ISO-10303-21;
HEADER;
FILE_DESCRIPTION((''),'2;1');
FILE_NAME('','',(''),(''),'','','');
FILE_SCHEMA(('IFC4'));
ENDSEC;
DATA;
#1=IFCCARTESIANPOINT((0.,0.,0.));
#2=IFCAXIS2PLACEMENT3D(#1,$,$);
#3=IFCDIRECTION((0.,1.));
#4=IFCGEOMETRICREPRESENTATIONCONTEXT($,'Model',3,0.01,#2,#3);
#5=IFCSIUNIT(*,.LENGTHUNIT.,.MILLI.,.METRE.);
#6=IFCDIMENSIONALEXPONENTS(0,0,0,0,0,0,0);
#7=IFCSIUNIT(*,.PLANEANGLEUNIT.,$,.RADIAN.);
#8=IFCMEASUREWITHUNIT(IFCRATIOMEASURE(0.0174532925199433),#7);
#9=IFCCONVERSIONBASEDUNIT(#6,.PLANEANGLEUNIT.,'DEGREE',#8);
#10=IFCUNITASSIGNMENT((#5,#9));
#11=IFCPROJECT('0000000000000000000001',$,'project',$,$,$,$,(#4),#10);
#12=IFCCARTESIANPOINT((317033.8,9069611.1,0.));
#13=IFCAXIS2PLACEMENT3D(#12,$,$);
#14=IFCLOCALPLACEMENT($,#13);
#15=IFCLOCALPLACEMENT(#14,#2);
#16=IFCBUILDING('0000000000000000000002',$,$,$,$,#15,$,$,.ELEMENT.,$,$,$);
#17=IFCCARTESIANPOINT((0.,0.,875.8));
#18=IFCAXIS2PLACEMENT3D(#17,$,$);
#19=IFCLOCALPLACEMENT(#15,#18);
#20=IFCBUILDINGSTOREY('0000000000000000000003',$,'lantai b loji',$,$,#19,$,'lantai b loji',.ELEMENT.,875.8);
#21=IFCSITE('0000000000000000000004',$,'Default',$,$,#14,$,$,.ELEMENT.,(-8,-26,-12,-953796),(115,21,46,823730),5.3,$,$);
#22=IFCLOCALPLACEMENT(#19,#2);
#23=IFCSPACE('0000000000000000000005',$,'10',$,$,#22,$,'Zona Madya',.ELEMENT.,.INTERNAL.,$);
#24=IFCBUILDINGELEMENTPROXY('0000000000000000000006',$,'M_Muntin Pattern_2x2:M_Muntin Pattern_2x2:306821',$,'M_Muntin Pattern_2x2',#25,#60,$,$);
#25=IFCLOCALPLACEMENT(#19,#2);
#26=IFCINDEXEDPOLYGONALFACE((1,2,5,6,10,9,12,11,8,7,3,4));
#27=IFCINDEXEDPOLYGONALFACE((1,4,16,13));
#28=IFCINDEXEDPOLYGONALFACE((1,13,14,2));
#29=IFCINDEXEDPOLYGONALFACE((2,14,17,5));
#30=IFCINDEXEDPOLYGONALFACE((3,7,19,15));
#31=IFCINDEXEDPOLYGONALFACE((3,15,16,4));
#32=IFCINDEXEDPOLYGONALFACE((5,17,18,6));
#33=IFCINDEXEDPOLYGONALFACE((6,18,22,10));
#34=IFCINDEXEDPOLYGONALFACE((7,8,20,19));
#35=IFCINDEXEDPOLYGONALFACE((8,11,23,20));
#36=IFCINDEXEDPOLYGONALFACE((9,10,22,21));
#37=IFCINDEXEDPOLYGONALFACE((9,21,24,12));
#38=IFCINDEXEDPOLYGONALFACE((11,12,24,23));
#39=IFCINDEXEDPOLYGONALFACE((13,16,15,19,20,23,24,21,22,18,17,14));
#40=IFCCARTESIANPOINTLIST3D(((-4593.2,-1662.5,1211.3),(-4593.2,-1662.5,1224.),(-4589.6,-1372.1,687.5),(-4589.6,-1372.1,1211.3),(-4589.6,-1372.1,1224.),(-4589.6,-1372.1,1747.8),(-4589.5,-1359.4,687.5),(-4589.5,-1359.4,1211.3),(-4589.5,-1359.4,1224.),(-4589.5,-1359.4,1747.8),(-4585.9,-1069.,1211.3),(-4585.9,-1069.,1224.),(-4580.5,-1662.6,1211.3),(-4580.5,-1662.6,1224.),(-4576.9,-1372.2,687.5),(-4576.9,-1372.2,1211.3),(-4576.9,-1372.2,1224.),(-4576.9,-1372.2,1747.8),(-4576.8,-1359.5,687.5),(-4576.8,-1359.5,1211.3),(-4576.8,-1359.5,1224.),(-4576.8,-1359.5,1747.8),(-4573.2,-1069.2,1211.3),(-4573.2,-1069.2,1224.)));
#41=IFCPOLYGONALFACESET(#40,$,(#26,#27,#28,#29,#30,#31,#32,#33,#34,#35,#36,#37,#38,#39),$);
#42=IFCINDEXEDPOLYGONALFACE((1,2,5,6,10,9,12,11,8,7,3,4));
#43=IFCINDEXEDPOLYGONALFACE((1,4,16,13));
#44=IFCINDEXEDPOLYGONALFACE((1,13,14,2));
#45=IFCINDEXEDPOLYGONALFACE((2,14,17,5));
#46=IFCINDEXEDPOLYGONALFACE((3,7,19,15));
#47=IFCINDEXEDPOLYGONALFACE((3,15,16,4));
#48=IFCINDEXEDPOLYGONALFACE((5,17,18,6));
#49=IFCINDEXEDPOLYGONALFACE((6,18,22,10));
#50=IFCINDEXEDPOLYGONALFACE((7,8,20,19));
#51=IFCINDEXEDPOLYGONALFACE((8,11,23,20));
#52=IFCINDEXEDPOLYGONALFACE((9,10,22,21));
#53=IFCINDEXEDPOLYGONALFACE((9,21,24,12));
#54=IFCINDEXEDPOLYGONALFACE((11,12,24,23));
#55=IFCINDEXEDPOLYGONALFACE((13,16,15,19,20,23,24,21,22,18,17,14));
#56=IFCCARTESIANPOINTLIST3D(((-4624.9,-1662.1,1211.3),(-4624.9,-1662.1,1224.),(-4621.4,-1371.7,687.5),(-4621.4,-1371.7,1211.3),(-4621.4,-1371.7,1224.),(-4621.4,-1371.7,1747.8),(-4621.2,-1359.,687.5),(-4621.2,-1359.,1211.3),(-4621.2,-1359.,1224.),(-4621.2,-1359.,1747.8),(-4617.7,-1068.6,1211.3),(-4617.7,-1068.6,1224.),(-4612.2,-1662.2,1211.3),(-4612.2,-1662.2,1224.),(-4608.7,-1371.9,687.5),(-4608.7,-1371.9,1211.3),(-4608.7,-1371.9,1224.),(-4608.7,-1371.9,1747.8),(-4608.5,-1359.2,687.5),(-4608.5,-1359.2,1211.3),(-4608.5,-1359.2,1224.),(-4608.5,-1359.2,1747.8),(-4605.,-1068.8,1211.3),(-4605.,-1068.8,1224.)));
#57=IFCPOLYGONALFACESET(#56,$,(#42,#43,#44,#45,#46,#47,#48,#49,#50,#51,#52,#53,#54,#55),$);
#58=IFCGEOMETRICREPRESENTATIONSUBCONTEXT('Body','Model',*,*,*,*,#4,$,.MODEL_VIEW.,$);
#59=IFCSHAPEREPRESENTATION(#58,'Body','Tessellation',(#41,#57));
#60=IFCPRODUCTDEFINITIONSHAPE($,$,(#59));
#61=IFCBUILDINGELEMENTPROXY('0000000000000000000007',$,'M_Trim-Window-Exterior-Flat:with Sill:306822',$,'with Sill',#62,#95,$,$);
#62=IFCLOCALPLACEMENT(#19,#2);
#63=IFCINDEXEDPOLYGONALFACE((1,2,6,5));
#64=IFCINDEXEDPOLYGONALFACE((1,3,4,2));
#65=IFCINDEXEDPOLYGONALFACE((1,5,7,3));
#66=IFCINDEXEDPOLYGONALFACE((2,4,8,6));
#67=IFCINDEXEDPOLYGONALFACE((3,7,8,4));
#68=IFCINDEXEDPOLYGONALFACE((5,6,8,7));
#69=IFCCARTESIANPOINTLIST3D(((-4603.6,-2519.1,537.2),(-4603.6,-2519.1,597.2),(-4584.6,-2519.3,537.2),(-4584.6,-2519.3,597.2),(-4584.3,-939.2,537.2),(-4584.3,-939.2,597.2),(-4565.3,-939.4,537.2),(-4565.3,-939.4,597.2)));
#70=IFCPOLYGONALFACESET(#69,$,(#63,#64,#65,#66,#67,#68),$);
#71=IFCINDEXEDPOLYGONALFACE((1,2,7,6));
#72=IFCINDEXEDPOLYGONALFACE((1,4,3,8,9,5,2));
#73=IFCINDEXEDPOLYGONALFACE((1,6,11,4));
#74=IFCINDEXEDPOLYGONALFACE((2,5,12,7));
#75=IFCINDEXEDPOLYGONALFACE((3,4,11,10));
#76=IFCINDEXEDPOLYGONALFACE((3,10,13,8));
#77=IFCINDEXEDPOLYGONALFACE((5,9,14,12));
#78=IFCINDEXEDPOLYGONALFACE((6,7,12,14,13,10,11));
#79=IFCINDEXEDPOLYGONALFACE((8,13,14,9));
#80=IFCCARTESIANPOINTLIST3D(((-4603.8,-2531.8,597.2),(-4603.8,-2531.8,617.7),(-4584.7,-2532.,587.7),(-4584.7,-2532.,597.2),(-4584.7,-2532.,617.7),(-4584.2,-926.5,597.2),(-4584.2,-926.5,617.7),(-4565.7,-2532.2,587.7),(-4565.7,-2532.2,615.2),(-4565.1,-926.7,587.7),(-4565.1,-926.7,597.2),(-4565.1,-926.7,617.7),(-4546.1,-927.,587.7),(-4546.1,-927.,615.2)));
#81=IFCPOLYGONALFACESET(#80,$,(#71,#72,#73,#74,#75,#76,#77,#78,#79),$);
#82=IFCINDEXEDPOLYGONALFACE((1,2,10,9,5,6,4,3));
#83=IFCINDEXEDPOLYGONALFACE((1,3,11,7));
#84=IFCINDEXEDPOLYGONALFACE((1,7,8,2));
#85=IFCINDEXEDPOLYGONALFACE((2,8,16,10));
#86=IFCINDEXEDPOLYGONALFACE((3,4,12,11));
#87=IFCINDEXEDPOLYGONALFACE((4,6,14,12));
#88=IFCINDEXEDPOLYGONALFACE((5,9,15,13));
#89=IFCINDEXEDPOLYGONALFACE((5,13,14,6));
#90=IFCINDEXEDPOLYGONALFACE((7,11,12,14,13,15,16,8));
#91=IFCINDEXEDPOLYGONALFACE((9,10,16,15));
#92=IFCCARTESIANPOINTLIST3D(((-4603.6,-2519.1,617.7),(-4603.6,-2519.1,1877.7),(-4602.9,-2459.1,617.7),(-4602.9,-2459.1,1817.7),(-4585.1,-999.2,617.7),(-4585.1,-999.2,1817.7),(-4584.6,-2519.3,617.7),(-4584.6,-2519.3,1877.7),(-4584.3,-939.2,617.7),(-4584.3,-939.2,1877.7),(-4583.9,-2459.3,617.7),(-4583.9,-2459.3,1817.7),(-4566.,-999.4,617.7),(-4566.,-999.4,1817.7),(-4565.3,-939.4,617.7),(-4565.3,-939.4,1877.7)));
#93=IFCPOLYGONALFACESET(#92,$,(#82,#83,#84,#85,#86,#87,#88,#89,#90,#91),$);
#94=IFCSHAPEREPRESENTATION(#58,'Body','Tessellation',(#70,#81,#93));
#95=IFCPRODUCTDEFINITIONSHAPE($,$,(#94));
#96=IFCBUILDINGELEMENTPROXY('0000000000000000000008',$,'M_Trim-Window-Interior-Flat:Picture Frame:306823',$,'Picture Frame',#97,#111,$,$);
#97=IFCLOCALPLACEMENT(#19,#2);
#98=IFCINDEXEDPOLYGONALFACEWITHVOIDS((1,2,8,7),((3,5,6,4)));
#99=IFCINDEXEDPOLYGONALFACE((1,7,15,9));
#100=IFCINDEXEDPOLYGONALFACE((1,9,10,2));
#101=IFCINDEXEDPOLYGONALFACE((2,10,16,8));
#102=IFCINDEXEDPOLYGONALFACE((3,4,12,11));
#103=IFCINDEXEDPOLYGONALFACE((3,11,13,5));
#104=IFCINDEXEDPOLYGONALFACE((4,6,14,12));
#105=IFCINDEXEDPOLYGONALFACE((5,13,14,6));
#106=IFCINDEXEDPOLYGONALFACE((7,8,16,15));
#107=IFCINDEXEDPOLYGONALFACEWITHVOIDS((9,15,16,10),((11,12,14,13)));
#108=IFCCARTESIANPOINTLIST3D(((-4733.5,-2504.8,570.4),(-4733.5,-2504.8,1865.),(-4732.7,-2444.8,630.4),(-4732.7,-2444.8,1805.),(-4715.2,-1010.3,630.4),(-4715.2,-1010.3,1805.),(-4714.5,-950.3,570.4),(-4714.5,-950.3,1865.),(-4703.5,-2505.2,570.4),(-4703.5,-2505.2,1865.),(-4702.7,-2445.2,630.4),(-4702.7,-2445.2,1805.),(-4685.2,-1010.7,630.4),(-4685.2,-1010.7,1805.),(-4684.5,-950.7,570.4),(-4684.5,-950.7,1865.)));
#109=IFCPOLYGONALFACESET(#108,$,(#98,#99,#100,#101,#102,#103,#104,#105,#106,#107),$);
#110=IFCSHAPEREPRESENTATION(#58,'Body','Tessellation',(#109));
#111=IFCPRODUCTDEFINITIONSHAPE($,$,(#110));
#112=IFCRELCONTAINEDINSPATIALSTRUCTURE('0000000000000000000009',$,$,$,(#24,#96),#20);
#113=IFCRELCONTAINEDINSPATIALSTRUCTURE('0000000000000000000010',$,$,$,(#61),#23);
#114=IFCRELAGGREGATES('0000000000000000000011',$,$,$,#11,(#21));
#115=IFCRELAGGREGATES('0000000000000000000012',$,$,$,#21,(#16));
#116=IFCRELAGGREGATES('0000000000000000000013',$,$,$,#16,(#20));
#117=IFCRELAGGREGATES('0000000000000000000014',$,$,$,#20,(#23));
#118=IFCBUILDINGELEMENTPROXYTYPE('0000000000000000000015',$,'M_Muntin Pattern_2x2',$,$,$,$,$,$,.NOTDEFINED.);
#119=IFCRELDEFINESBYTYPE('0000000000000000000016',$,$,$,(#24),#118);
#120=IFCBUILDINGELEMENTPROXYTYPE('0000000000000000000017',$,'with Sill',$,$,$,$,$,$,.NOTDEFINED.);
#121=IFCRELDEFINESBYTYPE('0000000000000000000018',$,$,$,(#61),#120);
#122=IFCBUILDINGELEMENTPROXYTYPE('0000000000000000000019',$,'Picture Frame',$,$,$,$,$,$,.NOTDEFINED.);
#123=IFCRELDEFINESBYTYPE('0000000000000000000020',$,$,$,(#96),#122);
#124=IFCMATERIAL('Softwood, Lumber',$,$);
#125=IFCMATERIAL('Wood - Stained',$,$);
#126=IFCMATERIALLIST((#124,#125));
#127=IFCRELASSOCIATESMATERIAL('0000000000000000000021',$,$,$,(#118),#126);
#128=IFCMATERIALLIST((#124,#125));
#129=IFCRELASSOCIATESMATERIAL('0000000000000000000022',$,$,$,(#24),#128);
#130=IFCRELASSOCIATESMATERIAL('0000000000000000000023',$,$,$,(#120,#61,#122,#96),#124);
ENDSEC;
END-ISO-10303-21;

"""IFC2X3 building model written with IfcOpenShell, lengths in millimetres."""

from ifc_helpers import new_model, entity, si_unit, converted_unit, direction, frame, frame_2d, origin, place, context, subcontext, project, spatial, polyline, rectangle, outline, extrude, source, transform, mapped, material, material_list, type_object, type_shapes, element, save


model = new_model("IFC2X3")

# Units and contexts
model_context = context("Model", 3, precision=0.01, world=origin(), true_north=direction((0.0, 1.0)))
body_context = subcontext(model_context, "Body", "Model", "MODEL_VIEW")
ifc_project = project(units=[si_unit("LENGTHUNIT", "METRE", prefix="MILLI"), converted_unit("PLANEANGLEUNIT", "DEGREE", entity("IfcRatioMeasure", 0.0174532925199433), si_unit("PLANEANGLEUNIT", "RADIAN"), dimensions=[0, 0, 0, 0, 0, 0, 0])], contexts=[model_context])

# Site, building, storey
site_placement = place(None, frame((317033.8, 9069611.1, 0.0)))
site = spatial("IfcSite", under=ifc_project, at=site_placement, Name="Default", CompositionType="ELEMENT", RefLatitude=(-8, -26, -12, -953796), RefLongitude=(115, 21, 46, 823730), RefElevation=5.3)
building_placement = place(site_placement, origin())
building = spatial("IfcBuilding", under=site, at=building_placement, CompositionType="ELEMENT")
storey_placement = place(building_placement, frame((0.0, 0.0, 875.8)))
storey = spatial("IfcBuildingStorey", under=building, at=storey_placement, Name="lantai b loji", LongName="lantai b loji", CompositionType="ELEMENT", Elevation=875.8)

# Shared definitions
space_placement = place(storey_placement, origin())
space = spatial("IfcSpace", under=storey, at=space_placement, Name="10", LongName="Zona Madya", CompositionType="ELEMENT", InteriorOrExteriorSpace="INTERNAL")

# Building element proxies
ifc_material_1 = material(Name="Softwood, Lumber")
ifc_material_2 = material(Name="Wood - Stained")
ifc_material_list_1 = material_list([ifc_material_1, ifc_material_2])
ifc_material_list_2 = material_list([ifc_material_1, ifc_material_2])
building_element_proxy_type_1 = type_object("IfcBuildingElementProxyType", Name="M_Muntin Pattern_2x2", PredefinedType="NOTDEFINED", material=ifc_material_list_2)
shared_shape_1 = source(origin(), body_context, "Body", "SweptSolid", [
    extrude(outline(polyline([(6.4, -6.4), (530.1, -6.4), (530.1, 6.3), (6.4, 6.3), (6.4, 296.7), (-6.3, 296.7), (-6.3, 6.3), (-530.2, 6.3), (-530.2, -6.4), (-6.3, -6.4), (-6.3, -296.7), (6.4, -296.7), (6.4, -6.4)])), frame((0.0, 9.5, 530.1), z_axis=(0.0, 1.0, 0.0), x_axis=(0.0, 0.0, 1.0)), (0.0, 0.0, 1.0), 12.7),
    extrude(outline(polyline([(6.4, -6.4), (530.1, -6.4), (530.1, 6.3), (6.4, 6.3), (6.4, 296.7), (-6.3, 296.7), (-6.3, 6.3), (-530.2, 6.3), (-530.2, -6.4), (-6.3, -6.4), (-6.3, -296.7), (6.4, -296.7), (6.4, -6.4)])), frame((0.0, -22.2, 530.2), z_axis=(0.0, 1.0, 0.0), x_axis=(0.0, 0.0, 1.0)), (0.0, 0.0, 1.0), 12.7),
])
type_shapes(building_element_proxy_type_1, [shared_shape_1])
proxy_1_placement = place(storey_placement, frame((-4599.1, -1365.6, 687.5), z_axis=(0.0, 0.0, 1.0), x_axis=(-0.012208, -0.999925, 0.0)))
element("IfcBuildingElementProxy", 1, at=proxy_1_placement, inside=storey, type_object=building_element_proxy_type_1, material=ifc_material_list_1, Name="M_Muntin Pattern_2x2:M_Muntin Pattern_2x2:306821", ObjectType="M_Muntin Pattern_2x2", context=body_context, shape_type="MappedRepresentation", body=[
    mapped(shared_shape_1, transform((0.0, 0.0, 0.0), scale=1.0)),
])
building_element_proxy_type_2 = type_object("IfcBuildingElementProxyType", Name="with Sill", PredefinedType="NOTDEFINED", material=ifc_material_1)
shared_shape_2 = source(origin(), body_context, "Body", "SweptSolid", [
    extrude(rectangle(XDim=60.0, YDim=1580.0, at=frame_2d((0.0, 0.0), x_axis=(1.0, 0.0))), frame((0.0, 1250.4, 0.0), z_axis=(0.0, 0.0, 1.0), x_axis=(0.0, 1.0, 0.0)), (0.0, 0.0, 1.0), 19.1),
    extrude(outline(polyline([(-15.2, -19.0), (12.3, -19.0), (14.8, 0.0), (14.8, 19.0), (-5.7, 19.0), (-5.7, 0.0), (-15.2, 0.0), (-15.2, -19.0)])), frame((-802.7, 1214.8, 19.0), z_axis=(1.0, 0.0, 0.0), x_axis=(0.0, -1.0, 0.0)), (0.0, 0.0, 1.0), 1605.4),
    extrude(outline(polyline([(-790.0, -645.0), (790.0, -645.0), (790.0, 615.0), (730.0, 615.0), (730.0, -585.0), (-730.0, -585.0), (-730.0, 615.0), (-790.0, 615.0), (-790.0, -645.0)])), frame((0.0, 585.0, 0.0)), (0.0, 0.0, 1.0), 19.1),
])
type_shapes(building_element_proxy_type_2, [shared_shape_2])
proxy_2_placement = place(space_placement, frame((-4594.0, -1729.1, 1817.7), z_axis=(0.999925, -0.012208, 0.0), x_axis=(-0.012208, -0.999925, 0.0)))
element("IfcBuildingElementProxy", 2, at=proxy_2_placement, inside=space, type_object=building_element_proxy_type_2, material=ifc_material_1, Name="M_Trim-Window-Exterior-Flat:with Sill:306822", ObjectType="with Sill", context=body_context, shape_type="MappedRepresentation", body=[
    mapped(shared_shape_2, transform((0.0, 0.0, 0.0), scale=1.0)),
])
building_element_proxy_type_3 = type_object("IfcBuildingElementProxyType", Name="Picture Frame", PredefinedType="NOTDEFINED", material=ifc_material_1)
shared_shape_3 = source(origin(), body_context, "Body", "SweptSolid", [
    extrude(outline(polyline([(-647.3, -777.3), (647.3, -777.3), (647.3, 777.3), (-647.3, 777.3), (-647.3, -777.3)]), holes=[polyline([(-587.3, -717.3), (-587.3, 717.3), (587.3, 717.3), (587.3, -717.3), (-587.3, -717.3)])]), frame((0.0, 600.0, 0.0), z_axis=(0.0, 0.0, 1.0), x_axis=(0.0, 1.0, 0.0)), (0.0, 0.0, 1.0), 30.0),
])
type_shapes(building_element_proxy_type_3, [shared_shape_3])
proxy_3_placement = place(storey_placement, frame((-4694.0, -1727.9, 1817.7), z_axis=(-0.999925, 0.012208, 0.0), x_axis=(0.012208, 0.999925, 0.0)))
element("IfcBuildingElementProxy", 3, at=proxy_3_placement, inside=storey, type_object=building_element_proxy_type_3, material=ifc_material_1, Name="M_Trim-Window-Interior-Flat:Picture Frame:306823", ObjectType="Picture Frame", context=body_context, shape_type="MappedRepresentation", body=[
    mapped(shared_shape_3, transform((0.0, 0.0, 0.0), scale=1.0)),
])

save(model, "model.ifc")
